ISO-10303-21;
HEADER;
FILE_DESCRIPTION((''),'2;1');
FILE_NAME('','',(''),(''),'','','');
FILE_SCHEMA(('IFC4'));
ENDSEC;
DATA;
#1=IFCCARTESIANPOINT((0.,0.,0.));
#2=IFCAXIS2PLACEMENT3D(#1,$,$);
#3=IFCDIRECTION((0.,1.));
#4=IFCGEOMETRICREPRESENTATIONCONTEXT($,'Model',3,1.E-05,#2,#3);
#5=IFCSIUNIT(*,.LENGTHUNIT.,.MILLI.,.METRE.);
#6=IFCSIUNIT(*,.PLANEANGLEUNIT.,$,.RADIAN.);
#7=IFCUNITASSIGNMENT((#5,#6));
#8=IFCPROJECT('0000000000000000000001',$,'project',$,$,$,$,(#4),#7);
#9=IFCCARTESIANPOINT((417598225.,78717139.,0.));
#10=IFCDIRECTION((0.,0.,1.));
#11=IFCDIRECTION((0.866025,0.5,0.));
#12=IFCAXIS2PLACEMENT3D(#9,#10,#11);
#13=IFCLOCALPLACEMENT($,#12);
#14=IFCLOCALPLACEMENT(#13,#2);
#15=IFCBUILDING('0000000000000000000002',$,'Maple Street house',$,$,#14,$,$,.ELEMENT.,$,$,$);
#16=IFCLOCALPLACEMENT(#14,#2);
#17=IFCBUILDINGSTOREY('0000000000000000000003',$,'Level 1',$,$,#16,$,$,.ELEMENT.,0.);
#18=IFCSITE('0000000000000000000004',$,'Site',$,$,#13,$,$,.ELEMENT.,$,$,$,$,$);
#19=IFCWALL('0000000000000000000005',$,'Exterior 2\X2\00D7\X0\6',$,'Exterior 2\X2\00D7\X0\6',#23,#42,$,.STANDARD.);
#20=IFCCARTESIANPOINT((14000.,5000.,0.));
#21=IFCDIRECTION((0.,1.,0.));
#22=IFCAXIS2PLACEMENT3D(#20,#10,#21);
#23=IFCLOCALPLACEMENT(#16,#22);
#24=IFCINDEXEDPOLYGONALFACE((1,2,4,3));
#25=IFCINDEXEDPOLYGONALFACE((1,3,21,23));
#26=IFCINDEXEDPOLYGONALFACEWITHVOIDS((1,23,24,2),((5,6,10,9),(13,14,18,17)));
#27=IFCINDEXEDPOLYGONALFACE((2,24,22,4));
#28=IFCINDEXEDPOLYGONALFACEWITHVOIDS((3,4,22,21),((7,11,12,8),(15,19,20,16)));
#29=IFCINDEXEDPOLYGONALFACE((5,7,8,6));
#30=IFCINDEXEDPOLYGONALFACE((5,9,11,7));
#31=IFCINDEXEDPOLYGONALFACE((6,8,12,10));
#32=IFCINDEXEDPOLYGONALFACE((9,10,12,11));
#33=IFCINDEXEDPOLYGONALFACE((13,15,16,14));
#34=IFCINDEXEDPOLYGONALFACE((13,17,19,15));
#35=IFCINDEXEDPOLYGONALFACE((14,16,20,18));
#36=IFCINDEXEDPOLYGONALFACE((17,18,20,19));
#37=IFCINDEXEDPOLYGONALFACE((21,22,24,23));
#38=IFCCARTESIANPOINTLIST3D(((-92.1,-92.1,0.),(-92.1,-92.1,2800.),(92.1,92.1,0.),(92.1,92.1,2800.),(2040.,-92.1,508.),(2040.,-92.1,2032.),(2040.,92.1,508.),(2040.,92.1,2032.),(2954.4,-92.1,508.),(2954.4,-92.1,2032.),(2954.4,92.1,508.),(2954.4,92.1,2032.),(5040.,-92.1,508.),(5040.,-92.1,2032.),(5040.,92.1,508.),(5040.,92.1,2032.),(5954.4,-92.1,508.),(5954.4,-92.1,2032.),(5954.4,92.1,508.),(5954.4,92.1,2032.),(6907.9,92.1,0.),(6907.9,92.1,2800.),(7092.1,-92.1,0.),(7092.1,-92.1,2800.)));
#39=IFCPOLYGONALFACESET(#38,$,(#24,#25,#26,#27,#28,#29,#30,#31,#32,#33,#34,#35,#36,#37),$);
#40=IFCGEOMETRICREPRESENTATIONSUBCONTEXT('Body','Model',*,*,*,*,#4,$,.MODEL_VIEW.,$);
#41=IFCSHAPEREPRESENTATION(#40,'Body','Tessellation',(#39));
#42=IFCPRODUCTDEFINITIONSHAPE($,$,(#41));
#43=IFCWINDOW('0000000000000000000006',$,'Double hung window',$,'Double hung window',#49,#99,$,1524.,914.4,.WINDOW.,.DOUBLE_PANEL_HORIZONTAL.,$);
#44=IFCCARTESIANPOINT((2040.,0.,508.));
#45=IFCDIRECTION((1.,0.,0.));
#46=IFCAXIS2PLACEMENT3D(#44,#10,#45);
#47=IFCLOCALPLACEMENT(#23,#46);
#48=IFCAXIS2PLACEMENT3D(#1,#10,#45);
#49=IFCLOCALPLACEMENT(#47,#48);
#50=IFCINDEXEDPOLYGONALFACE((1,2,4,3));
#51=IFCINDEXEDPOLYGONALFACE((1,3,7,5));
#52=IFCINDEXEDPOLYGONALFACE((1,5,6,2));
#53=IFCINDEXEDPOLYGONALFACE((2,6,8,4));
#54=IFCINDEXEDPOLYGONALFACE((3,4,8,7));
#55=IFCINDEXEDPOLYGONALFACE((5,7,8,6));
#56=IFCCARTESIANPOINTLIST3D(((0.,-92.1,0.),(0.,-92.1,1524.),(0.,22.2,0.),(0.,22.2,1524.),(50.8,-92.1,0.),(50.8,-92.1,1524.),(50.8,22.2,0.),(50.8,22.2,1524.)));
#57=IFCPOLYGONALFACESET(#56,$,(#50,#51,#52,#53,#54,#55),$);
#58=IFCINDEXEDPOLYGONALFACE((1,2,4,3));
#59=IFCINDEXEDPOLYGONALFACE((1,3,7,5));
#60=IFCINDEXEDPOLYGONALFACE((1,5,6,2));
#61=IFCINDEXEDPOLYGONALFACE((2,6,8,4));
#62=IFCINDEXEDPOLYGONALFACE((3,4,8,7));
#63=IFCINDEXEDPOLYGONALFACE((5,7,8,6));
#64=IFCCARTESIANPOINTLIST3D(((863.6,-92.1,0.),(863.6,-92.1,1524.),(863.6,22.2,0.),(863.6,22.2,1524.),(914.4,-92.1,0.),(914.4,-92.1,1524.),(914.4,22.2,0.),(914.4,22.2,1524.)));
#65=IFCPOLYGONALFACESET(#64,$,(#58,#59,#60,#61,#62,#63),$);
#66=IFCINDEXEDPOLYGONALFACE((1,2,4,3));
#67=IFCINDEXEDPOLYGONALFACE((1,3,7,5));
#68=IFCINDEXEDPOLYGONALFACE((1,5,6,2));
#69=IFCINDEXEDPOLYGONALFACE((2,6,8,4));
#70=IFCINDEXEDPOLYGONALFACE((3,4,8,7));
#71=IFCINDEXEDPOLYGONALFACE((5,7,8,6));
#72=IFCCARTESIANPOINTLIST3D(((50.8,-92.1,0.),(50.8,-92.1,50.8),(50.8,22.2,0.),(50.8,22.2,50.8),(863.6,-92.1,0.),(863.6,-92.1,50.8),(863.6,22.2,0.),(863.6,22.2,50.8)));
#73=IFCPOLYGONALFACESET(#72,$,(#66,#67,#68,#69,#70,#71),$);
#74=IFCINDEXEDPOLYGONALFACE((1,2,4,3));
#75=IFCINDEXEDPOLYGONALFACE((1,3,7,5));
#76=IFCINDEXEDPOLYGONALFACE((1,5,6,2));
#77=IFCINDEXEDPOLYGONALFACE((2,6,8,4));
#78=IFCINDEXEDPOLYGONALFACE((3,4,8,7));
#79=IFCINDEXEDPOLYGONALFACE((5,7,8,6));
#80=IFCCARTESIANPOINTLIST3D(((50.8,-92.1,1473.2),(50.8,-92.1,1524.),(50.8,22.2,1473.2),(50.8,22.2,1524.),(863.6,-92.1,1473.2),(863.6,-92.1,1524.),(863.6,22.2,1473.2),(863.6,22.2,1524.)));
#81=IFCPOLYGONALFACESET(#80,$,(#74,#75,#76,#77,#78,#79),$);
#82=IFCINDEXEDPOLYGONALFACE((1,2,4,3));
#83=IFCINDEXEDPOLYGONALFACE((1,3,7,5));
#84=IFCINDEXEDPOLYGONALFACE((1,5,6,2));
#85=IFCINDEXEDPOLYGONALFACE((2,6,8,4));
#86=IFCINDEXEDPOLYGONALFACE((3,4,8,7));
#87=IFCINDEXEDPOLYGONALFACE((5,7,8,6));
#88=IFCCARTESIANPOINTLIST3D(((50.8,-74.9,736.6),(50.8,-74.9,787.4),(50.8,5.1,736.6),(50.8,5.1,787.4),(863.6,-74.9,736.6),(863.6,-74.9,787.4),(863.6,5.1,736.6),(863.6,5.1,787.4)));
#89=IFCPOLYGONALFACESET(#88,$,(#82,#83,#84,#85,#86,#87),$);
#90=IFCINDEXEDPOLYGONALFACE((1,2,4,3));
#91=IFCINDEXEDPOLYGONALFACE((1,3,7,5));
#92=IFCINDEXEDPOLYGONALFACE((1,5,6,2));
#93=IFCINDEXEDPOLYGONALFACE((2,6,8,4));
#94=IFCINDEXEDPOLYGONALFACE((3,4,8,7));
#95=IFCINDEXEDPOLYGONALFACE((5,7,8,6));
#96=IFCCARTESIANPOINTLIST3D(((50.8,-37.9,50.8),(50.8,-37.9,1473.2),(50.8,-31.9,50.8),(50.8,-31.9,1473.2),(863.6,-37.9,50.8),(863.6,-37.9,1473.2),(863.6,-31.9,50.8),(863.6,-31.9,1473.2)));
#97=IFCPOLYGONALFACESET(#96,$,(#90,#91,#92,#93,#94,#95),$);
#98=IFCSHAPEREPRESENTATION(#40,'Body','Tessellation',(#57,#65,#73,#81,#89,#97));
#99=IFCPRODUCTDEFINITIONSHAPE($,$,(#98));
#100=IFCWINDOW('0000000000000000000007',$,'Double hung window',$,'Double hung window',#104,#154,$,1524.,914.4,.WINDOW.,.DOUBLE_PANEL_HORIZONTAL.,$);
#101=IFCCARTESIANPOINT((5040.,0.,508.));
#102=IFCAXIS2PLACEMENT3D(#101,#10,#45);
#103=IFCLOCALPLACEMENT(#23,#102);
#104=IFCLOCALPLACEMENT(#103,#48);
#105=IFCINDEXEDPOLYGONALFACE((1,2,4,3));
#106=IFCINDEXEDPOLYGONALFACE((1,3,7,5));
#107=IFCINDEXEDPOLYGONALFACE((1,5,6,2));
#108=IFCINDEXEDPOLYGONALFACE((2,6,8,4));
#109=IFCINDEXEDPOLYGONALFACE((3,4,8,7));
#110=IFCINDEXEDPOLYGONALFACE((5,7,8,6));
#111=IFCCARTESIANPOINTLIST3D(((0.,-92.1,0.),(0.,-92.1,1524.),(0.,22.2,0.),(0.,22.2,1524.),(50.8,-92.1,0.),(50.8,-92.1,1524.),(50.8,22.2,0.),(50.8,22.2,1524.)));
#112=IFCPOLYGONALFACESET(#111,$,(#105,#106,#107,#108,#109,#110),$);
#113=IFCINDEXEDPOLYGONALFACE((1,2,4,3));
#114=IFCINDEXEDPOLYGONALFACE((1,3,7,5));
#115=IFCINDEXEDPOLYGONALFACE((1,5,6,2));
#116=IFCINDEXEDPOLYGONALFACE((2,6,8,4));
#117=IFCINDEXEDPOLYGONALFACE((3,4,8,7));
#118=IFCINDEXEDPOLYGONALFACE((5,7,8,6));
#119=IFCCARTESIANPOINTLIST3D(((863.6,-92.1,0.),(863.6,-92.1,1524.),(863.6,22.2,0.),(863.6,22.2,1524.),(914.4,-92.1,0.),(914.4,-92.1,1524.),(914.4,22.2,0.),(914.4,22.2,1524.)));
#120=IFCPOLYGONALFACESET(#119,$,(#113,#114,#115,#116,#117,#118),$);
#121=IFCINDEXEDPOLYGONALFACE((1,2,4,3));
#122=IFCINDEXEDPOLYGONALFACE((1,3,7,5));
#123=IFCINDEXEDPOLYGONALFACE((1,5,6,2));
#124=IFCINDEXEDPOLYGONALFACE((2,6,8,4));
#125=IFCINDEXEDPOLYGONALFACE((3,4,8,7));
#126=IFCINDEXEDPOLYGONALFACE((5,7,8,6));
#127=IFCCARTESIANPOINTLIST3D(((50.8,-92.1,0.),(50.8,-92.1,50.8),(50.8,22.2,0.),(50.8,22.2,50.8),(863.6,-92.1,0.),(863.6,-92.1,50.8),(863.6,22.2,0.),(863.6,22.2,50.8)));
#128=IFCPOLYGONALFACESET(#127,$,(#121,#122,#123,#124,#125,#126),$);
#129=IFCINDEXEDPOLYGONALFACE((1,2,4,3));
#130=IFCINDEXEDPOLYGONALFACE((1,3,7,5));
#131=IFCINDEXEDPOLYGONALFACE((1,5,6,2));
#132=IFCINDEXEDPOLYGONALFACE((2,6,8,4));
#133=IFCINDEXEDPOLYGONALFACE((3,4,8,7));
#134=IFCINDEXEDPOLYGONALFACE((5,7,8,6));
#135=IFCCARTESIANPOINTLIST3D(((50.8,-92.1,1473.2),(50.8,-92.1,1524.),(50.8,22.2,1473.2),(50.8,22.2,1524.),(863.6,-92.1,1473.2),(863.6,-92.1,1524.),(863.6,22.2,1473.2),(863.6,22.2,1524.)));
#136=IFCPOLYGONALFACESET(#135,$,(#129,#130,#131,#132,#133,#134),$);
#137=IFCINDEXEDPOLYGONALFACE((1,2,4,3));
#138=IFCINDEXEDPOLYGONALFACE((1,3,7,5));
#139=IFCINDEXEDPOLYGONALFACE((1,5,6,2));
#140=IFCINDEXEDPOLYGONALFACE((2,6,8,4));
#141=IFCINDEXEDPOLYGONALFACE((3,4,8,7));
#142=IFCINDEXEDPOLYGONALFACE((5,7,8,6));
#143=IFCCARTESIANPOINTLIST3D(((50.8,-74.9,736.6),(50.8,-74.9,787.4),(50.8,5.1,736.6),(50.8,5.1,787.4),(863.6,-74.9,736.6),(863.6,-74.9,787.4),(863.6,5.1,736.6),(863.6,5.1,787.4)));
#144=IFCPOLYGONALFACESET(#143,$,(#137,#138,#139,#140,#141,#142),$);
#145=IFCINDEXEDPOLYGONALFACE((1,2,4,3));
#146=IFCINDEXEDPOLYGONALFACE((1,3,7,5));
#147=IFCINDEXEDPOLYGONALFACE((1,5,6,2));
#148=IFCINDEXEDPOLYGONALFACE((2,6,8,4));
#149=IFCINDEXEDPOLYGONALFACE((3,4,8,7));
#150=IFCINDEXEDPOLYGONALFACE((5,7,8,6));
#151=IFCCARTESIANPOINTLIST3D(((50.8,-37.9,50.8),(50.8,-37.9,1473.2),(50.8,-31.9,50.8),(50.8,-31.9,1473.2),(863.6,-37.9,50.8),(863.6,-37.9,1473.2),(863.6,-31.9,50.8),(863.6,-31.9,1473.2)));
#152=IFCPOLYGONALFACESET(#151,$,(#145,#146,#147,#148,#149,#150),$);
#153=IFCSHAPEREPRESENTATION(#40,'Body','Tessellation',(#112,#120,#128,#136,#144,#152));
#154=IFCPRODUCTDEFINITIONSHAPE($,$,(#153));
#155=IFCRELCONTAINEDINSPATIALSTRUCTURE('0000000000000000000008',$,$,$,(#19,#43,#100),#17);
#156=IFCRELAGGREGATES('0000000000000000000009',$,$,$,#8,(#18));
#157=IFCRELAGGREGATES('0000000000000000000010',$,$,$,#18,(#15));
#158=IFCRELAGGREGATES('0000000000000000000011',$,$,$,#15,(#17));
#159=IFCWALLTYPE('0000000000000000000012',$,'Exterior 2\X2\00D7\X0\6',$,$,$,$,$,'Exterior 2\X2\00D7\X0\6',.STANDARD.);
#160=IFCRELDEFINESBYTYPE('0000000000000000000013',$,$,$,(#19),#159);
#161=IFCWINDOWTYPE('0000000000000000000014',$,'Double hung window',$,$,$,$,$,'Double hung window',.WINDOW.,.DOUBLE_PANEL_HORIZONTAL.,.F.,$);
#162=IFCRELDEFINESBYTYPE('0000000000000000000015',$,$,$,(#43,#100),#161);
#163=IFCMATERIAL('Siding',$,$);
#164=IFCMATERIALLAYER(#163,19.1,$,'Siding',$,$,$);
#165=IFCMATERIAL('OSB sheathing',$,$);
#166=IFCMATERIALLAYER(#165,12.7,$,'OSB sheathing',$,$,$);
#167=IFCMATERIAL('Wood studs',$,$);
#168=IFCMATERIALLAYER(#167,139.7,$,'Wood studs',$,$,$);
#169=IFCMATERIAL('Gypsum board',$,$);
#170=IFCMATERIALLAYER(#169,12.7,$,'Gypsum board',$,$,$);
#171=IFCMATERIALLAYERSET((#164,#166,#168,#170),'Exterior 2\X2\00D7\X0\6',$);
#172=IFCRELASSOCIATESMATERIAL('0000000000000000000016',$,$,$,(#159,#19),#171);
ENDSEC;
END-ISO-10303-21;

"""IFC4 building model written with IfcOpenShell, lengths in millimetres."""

from ifc_helpers import new_model, si_unit, direction, frame, origin, origin_with_axes, place, context, subcontext, project, spatial, polyline, outline, extrude, material, layer, layer_set, layer_usage, type_object, element, fill, save


model = new_model("IFC4")

# Units and contexts
model_context = context("Model", 3, precision=1e-05, world=origin(), true_north=direction((0.0, 1.0)))
body_context = subcontext(model_context, "Body", "Model", "MODEL_VIEW")
ifc_project = project(units=[si_unit("LENGTHUNIT", "METRE", prefix="MILLI"), si_unit("PLANEANGLEUNIT", "RADIAN")], contexts=[model_context])

# Site, building, storey
site_placement = place(None, frame((417598225.0, 78717139.0, 0.0), z_axis=(0.0, 0.0, 1.0), x_axis=(0.866025, 0.5, 0.0)))
site = spatial("IfcSite", under=ifc_project, at=site_placement, Name="Site", CompositionType="ELEMENT")
building_placement = place(site_placement, origin())
building = spatial("IfcBuilding", under=site, at=building_placement, Name="Maple Street house", CompositionType="ELEMENT")
storey_placement = place(building_placement, origin())
storey = spatial("IfcBuildingStorey", under=building, at=storey_placement, Name="Level 1", CompositionType="ELEMENT", Elevation=0.0)

# Shared definitions
ifc_material_1 = material(Name="Siding")
ifc_layer_1 = layer(ifc_material_1, 19.1, Name="Siding")
ifc_material_2 = material(Name="OSB sheathing")
ifc_layer_2 = layer(ifc_material_2, 12.7, Name="OSB sheathing")
ifc_material_3 = material(Name="Wood studs")
ifc_layer_3 = layer(ifc_material_3, 139.7, Name="Wood studs")
ifc_material_4 = material(Name="Gypsum board")
ifc_layer_4 = layer(ifc_material_4, 12.7, Name="Gypsum board")
ifc_layer_set_1 = layer_set([ifc_layer_1, ifc_layer_2, ifc_layer_3, ifc_layer_4], Name="Exterior 2×6")
wall_type_1 = type_object("IfcWallType", Name="Exterior 2×6", ElementType="Exterior 2×6", PredefinedType="STANDARD", material=ifc_layer_set_1)

# Wall, openings, windows
ifc_layer_usage_1 = layer_usage(ifc_layer_set_1, "AXIS2", "POSITIVE", -92.1)
wall_1_placement = place(storey_placement, frame((14000.0, 5000.0, 0.0), z_axis=(0.0, 0.0, 1.0), x_axis=(0.0, 1.0, 0.0)))
wall_1 = element("IfcWall", 1, at=wall_1_placement, inside=storey, type_object=wall_type_1, material=ifc_layer_usage_1, Name="Exterior 2×6", ObjectType="Exterior 2×6", PredefinedType="STANDARD", context=body_context, shape_type="SweptSolid", body=[
    extrude(outline(polyline([(-92.1, -92.1), (7092.1, -92.1), (6907.9, 92.1), (92.1, 92.1), (-92.1, -92.1)])), origin(), (0.0, 0.0, 1.0), 2800.0),
])
opening_1_placement = place(wall_1_placement, frame((2040.0, 0.0, 508.0), z_axis=(0.0, 0.0, 1.0), x_axis=(1.0, 0.0, 0.0)))
opening_1 = element("IfcOpeningElement", 2, at=opening_1_placement, cuts=wall_1, PredefinedType="OPENING", context=body_context, shape_type="SweptSolid", body=[
    extrude(outline(polyline([(0.0, -102.1), (914.4, -102.1), (914.4, 102.1), (0.0, 102.1), (0.0, -102.1)])), origin(), (0.0, 0.0, 1.0), 1524.0),
])
opening_2_placement = place(wall_1_placement, frame((5040.0, 0.0, 508.0), z_axis=(0.0, 0.0, 1.0), x_axis=(1.0, 0.0, 0.0)))
opening_2 = element("IfcOpeningElement", 3, at=opening_2_placement, cuts=wall_1, PredefinedType="OPENING", context=body_context, shape_type="SweptSolid", body=[
    extrude(outline(polyline([(0.0, -102.1), (914.4, -102.1), (914.4, 102.1), (0.0, 102.1), (0.0, -102.1)])), origin(), (0.0, 0.0, 1.0), 1524.0),
])
window_type_1 = type_object("IfcWindowType", Name="Double hung window", ElementType="Double hung window", ParameterTakesPrecedence=False, PartitioningType="DOUBLE_PANEL_HORIZONTAL", PredefinedType="WINDOW")
window_1_placement = place(opening_1_placement, origin_with_axes())
window_1 = element("IfcWindow", 4, at=window_1_placement, inside=storey, type_object=window_type_1, Name="Double hung window", ObjectType="Double hung window", OverallHeight=1524.0, OverallWidth=914.4, PartitioningType="DOUBLE_PANEL_HORIZONTAL", PredefinedType="WINDOW", context=body_context, shape_type="SweptSolid", body=[
    extrude(outline(polyline([(0.0, -92.1), (50.8, -92.1), (50.8, 22.2), (0.0, 22.2), (0.0, -92.1)])), origin(), (0.0, 0.0, 1.0), 1524.0),
    extrude(outline(polyline([(863.6, -92.1), (914.4, -92.1), (914.4, 22.2), (863.6, 22.2), (863.6, -92.1)])), origin(), (0.0, 0.0, 1.0), 1524.0),
    extrude(outline(polyline([(50.8, -92.1), (863.6, -92.1), (863.6, 22.2), (50.8, 22.2), (50.8, -92.1)])), origin(), (0.0, 0.0, 1.0), 50.8),
    extrude(outline(polyline([(50.8, -92.1), (863.6, -92.1), (863.6, 22.2), (50.8, 22.2), (50.8, -92.1)])), frame((0.0, 0.0, 1473.2)), (0.0, 0.0, 1.0), 50.8),
    extrude(outline(polyline([(50.8, -74.9), (863.6, -74.9), (863.6, 5.1), (50.8, 5.1), (50.8, -74.9)])), frame((0.0, 0.0, 736.6)), (0.0, 0.0, 1.0), 50.8),
    extrude(outline(polyline([(50.8, -37.9), (863.6, -37.9), (863.6, -31.9), (50.8, -31.9), (50.8, -37.9)])), frame((0.0, 0.0, 50.8)), (0.0, 0.0, 1.0), 1422.4),
])
fill(opening_1, window_1)
window_2_placement = place(opening_2_placement, origin_with_axes())
window_2 = element("IfcWindow", 5, at=window_2_placement, inside=storey, type_object=window_type_1, Name="Double hung window", ObjectType="Double hung window", OverallHeight=1524.0, OverallWidth=914.4, PartitioningType="DOUBLE_PANEL_HORIZONTAL", PredefinedType="WINDOW", context=body_context, shape_type="SweptSolid", body=[
    extrude(outline(polyline([(0.0, -92.1), (50.8, -92.1), (50.8, 22.2), (0.0, 22.2), (0.0, -92.1)])), origin(), (0.0, 0.0, 1.0), 1524.0),
    extrude(outline(polyline([(863.6, -92.1), (914.4, -92.1), (914.4, 22.2), (863.6, 22.2), (863.6, -92.1)])), origin(), (0.0, 0.0, 1.0), 1524.0),
    extrude(outline(polyline([(50.8, -92.1), (863.6, -92.1), (863.6, 22.2), (50.8, 22.2), (50.8, -92.1)])), origin(), (0.0, 0.0, 1.0), 50.8),
    extrude(outline(polyline([(50.8, -92.1), (863.6, -92.1), (863.6, 22.2), (50.8, 22.2), (50.8, -92.1)])), frame((0.0, 0.0, 1473.2)), (0.0, 0.0, 1.0), 50.8),
    extrude(outline(polyline([(50.8, -74.9), (863.6, -74.9), (863.6, 5.1), (50.8, 5.1), (50.8, -74.9)])), frame((0.0, 0.0, 736.6)), (0.0, 0.0, 1.0), 50.8),
    extrude(outline(polyline([(50.8, -37.9), (863.6, -37.9), (863.6, -31.9), (50.8, -31.9), (50.8, -37.9)])), frame((0.0, 0.0, 50.8)), (0.0, 0.0, 1.0), 1422.4),
])
fill(opening_2, window_2)

save(model, "model.ifc")
